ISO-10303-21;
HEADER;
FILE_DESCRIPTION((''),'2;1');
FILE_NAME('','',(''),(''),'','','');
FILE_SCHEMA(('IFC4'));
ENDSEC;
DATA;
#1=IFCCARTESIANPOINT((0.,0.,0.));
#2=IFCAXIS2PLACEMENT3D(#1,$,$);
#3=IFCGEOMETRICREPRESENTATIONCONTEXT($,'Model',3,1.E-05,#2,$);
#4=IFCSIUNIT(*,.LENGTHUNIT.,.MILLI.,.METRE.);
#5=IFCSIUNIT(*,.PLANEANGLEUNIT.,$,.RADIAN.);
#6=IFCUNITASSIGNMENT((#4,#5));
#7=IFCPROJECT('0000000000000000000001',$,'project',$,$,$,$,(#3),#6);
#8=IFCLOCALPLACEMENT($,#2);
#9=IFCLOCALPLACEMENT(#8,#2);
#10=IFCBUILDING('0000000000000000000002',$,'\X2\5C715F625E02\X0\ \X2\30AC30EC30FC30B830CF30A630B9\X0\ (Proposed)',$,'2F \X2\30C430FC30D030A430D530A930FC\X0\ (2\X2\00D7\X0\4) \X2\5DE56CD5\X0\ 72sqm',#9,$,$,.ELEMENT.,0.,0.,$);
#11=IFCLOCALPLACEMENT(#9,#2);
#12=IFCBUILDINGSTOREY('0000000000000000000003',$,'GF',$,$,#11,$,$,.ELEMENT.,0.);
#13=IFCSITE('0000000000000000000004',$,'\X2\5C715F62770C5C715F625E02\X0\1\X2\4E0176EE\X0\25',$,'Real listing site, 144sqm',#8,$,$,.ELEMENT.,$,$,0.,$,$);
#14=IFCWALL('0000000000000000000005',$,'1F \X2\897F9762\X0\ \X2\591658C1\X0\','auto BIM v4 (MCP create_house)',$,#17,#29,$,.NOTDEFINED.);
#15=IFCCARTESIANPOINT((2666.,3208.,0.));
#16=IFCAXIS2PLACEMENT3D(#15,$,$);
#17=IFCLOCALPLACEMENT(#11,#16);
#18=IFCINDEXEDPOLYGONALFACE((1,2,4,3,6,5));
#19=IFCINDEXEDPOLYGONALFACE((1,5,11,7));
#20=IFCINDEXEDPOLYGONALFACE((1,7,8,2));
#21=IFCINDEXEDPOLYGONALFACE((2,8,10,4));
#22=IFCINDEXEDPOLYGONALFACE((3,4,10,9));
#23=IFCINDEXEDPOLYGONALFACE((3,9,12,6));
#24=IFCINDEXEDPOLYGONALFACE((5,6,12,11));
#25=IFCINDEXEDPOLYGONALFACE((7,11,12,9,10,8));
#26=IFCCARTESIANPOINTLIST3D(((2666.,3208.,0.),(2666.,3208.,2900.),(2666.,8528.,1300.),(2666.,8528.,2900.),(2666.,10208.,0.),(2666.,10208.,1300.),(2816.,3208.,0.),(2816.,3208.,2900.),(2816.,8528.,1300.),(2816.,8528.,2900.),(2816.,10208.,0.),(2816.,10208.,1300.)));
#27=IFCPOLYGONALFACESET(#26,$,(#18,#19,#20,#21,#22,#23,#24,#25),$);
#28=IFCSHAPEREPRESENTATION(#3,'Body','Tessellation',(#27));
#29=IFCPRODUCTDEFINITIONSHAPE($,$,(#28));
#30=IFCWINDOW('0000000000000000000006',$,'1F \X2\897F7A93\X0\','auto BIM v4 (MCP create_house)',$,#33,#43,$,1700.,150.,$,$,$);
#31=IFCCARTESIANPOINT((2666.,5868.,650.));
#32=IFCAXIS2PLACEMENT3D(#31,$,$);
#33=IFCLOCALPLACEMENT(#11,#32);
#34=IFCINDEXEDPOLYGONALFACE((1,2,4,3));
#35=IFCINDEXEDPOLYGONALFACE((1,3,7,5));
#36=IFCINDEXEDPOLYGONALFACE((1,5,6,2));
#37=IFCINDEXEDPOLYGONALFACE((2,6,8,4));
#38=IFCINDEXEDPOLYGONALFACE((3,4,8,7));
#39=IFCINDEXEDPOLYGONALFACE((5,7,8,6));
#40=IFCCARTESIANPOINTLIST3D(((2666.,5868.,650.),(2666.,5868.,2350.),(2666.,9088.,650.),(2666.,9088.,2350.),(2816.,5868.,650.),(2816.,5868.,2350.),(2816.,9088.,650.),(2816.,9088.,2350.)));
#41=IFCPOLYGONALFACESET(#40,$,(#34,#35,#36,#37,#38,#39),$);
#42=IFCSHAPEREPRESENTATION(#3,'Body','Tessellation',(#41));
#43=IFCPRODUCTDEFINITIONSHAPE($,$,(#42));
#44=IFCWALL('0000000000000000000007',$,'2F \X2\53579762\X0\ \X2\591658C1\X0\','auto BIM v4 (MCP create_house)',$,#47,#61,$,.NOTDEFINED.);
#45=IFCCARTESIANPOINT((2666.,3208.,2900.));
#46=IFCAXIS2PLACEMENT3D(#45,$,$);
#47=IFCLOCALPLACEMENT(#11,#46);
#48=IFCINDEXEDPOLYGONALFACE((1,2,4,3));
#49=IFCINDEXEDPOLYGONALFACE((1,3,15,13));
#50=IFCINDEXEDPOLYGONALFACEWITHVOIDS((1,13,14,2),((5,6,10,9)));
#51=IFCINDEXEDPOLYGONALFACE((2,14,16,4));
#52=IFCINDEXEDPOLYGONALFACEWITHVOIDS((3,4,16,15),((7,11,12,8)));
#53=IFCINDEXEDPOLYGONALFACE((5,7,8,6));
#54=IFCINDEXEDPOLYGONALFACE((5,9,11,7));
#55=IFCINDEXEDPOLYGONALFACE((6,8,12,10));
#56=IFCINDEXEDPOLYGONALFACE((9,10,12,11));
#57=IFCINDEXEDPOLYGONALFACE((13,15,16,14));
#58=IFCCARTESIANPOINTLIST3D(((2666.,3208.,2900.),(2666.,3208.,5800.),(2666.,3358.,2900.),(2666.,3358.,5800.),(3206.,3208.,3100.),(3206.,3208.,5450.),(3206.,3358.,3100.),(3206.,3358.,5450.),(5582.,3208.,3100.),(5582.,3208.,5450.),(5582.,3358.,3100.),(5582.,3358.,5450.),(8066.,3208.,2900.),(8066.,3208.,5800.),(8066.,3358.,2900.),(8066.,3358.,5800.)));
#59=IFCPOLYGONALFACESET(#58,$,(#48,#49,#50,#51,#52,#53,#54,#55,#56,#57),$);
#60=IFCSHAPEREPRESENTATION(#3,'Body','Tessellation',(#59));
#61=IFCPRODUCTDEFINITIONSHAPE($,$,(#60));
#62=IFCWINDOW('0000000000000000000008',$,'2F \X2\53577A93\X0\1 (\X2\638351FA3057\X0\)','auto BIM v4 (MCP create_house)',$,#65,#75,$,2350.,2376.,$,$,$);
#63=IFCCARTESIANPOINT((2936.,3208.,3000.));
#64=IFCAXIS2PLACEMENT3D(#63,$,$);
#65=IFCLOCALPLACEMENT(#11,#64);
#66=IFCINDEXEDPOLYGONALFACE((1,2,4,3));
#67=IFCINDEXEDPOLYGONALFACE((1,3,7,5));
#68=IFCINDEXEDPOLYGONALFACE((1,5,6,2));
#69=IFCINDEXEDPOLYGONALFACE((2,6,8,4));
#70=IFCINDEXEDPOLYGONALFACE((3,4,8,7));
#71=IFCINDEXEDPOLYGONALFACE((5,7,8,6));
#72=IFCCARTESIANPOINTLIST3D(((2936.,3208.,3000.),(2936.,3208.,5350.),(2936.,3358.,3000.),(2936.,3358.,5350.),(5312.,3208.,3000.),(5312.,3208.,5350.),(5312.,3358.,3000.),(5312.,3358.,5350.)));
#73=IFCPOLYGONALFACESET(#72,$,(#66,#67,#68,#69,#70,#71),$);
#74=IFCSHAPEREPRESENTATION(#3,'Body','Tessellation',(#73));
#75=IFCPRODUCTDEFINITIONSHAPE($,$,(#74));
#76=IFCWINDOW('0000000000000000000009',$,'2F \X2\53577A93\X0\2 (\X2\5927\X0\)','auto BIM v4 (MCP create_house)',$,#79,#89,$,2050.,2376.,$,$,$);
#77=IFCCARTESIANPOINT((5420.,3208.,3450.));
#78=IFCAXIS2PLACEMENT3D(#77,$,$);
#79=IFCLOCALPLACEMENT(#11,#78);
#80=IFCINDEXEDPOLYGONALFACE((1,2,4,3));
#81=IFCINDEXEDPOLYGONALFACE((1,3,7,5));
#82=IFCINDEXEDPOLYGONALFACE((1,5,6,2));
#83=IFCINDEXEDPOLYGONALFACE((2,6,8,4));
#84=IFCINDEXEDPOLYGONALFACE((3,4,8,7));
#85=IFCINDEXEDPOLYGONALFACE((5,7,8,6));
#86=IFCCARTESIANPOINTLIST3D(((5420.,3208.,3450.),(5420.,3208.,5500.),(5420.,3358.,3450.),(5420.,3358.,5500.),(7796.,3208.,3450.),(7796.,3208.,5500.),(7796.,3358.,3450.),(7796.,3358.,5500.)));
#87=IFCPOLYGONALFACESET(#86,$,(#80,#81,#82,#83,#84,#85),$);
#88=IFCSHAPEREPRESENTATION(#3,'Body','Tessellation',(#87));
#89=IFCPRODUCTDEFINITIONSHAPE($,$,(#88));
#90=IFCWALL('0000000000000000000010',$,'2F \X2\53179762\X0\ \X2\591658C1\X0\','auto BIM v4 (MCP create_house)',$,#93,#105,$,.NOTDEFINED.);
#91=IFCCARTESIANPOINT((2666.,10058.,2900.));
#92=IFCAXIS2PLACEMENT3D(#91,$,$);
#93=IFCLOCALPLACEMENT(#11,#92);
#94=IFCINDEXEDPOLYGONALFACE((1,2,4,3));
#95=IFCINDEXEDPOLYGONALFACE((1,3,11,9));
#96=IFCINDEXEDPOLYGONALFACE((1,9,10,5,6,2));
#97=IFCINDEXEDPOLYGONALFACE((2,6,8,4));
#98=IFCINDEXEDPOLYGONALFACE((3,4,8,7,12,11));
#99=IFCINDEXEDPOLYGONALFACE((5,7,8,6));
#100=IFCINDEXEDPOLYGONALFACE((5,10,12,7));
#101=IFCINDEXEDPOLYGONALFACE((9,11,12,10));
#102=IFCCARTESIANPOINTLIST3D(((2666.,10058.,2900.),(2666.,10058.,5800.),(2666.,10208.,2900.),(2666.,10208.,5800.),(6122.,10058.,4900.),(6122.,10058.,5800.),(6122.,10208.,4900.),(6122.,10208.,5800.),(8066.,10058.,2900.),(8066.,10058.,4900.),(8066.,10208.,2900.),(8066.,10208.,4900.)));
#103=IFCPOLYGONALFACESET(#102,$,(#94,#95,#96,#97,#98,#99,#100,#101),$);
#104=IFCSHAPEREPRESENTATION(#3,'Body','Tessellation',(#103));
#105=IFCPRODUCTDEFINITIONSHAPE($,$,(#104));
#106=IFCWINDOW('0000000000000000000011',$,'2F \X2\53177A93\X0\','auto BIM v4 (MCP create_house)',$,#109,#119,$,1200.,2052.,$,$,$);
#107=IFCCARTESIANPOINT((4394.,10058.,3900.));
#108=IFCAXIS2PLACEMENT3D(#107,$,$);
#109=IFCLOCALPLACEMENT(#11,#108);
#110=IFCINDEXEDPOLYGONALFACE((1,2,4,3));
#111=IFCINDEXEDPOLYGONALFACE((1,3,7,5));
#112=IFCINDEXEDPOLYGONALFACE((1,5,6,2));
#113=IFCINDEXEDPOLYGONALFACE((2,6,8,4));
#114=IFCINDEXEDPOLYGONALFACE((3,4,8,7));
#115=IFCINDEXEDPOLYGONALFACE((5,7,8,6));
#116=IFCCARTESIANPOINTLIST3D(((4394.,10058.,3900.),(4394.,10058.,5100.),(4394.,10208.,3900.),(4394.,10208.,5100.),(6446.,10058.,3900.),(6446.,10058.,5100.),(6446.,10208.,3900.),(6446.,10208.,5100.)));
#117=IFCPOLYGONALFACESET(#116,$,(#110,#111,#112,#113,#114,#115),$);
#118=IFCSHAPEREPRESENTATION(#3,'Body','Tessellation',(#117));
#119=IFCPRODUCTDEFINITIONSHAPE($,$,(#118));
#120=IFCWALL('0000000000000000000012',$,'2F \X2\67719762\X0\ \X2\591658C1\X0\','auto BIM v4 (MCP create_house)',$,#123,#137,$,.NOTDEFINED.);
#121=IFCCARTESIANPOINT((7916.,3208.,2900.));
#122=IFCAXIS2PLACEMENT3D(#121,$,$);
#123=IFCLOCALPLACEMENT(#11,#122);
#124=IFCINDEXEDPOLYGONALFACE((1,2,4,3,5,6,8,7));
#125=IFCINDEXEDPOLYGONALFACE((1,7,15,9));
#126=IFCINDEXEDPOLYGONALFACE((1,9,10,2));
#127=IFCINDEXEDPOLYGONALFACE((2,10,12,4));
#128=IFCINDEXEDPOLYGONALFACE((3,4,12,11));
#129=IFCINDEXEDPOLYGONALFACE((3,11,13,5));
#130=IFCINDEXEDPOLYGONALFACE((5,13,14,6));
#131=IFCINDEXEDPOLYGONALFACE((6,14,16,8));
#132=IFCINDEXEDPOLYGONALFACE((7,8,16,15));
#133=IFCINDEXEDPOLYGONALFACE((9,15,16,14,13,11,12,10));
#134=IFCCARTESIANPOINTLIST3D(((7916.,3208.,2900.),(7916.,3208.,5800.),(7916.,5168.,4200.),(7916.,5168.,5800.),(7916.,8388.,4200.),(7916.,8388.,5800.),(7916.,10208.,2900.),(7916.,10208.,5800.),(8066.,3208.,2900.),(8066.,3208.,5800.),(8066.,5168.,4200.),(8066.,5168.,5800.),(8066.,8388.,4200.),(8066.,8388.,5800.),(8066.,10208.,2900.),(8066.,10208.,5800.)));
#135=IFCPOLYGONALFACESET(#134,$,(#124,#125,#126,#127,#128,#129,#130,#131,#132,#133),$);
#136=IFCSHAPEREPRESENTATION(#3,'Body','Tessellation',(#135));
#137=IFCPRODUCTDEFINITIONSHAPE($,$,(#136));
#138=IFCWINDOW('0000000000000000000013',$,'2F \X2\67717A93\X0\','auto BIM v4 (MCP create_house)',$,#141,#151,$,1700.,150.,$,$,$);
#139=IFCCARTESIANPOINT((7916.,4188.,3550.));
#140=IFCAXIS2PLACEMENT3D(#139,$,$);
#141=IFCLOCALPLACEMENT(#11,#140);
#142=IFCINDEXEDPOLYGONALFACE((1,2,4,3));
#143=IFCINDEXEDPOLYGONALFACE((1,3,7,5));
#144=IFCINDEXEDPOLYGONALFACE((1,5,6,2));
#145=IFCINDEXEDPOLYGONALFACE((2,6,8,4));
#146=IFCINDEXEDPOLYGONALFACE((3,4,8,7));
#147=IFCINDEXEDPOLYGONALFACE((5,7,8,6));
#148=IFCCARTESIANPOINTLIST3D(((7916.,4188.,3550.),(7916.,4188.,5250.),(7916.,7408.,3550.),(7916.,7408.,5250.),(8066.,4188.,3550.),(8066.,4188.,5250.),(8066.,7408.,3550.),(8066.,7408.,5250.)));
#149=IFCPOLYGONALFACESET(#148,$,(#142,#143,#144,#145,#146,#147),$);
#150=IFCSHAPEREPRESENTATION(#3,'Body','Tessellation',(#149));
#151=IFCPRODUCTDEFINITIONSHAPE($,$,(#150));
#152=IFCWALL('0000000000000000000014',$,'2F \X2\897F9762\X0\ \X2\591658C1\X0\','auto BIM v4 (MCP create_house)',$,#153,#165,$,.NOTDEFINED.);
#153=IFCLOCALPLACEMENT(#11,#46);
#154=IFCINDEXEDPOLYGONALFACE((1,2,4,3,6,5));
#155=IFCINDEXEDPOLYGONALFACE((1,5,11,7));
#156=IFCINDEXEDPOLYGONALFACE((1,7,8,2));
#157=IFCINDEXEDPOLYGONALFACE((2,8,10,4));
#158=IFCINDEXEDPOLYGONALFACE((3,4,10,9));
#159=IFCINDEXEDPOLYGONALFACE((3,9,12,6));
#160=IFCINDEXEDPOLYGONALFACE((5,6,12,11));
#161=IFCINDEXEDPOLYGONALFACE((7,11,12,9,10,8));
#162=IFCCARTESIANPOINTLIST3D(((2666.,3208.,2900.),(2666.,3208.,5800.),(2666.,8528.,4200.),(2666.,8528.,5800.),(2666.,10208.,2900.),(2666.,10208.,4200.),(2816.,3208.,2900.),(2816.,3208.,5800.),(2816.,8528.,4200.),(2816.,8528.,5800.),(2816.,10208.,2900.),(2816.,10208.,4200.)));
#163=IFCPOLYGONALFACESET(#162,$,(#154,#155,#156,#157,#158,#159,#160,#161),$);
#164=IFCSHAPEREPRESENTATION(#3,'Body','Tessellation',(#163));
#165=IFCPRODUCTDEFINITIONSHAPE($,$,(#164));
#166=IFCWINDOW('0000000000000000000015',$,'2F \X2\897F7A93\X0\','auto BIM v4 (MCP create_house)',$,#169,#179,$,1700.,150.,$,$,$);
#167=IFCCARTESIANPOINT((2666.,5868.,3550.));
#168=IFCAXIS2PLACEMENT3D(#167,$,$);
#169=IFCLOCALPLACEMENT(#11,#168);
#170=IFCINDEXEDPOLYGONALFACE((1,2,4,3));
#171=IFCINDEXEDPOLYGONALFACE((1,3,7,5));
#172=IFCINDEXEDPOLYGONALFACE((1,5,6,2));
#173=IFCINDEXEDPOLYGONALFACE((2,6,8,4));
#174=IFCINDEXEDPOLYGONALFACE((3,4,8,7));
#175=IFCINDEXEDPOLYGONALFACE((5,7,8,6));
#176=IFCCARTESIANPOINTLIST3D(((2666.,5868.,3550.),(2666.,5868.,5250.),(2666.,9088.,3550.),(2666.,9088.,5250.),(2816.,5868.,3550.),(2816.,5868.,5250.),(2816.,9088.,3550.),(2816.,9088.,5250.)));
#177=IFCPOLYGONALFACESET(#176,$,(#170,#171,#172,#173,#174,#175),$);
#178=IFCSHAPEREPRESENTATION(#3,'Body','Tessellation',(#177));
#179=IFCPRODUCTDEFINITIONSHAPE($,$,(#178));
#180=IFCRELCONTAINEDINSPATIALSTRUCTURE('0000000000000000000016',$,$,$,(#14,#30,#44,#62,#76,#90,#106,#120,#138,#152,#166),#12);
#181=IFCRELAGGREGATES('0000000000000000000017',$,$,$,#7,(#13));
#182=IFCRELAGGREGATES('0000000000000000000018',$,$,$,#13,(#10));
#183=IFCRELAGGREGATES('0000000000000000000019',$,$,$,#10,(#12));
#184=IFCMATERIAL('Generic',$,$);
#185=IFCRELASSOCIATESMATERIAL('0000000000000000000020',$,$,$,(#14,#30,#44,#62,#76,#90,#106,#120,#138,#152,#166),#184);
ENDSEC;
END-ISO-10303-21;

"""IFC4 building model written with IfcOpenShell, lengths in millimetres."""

from ifc_helpers import new_model, si_unit, frame, frame_2d, origin, place, context, project, spatial, rectangle, extrude, material, element, fill, save


model = new_model("IFC4")

# Units and contexts
model_context = context("Model", 3, precision=1e-05, world=origin())
ifc_project = project(units=[si_unit("LENGTHUNIT", "METRE", prefix="MILLI"), si_unit("PLANEANGLEUNIT", "RADIAN")], contexts=[model_context])

# Site, building, storey
site_placement = place(None, origin())
site = spatial("IfcSite", under=ifc_project, at=site_placement, Name="山形県山形市1丁目25", ObjectType="Real listing site, 144sqm", CompositionType="ELEMENT", RefElevation=0.0)
building_placement = place(site_placement, origin())
building = spatial("IfcBuilding", under=site, at=building_placement, Name="山形市 ガレージハウス (Proposed)", ObjectType="2F ツーバイフォー (2×4) 工法 72sqm", CompositionType="ELEMENT", ElevationOfRefHeight=0.0, ElevationOfTerrain=0.0)
storey_placement = place(building_placement, origin())
storey = spatial("IfcBuildingStorey", under=building, at=storey_placement, Name="GF", CompositionType="ELEMENT", Elevation=0.0)

# Shared definitions
ifc_material = material(Name="Generic")

# Wall, opening, window
wall_1_placement = place(storey_placement, frame((2666.0, 3208.0, 0.0)))
wall_1 = element("IfcWall", 1, at=wall_1_placement, inside=storey, material=ifc_material, Name="1F 西面 外壁", Description="auto BIM v4 (MCP create_house)", PredefinedType="NOTDEFINED", context=model_context, shape_type="SweptSolid", body=[
    extrude(rectangle(XDim=150.0, YDim=7000.0, at=frame_2d((75.0, 3500.0))), frame((2666.0, 3208.0, 0.0)), (0.0, 0.0, 1.0), 2900.0),
])
opening_1_placement = place(storey_placement, frame((2666.0, 5868.0, 650.0)))
opening_1 = element("IfcOpeningElement", 2, at=opening_1_placement, cuts=wall_1, PredefinedType="NOTDEFINED", context=model_context, shape_type="SweptSolid", body=[
    extrude(rectangle(XDim=150.0, YDim=3220.0, at=frame_2d((75.0, 1610.0))), frame((2666.0, 5868.0, 650.0)), (0.0, 0.0, 1.0), 1700.0),
])
window_1_placement = place(storey_placement, frame((2666.0, 5868.0, 650.0)))
window_1 = element("IfcWindow", 3, at=window_1_placement, inside=storey, material=ifc_material, Name="1F 西窓", Description="auto BIM v4 (MCP create_house)", OverallHeight=1700.0, OverallWidth=150.0, context=model_context, shape_type="SweptSolid", body=[
    extrude(rectangle(XDim=150.0, YDim=3220.0, at=frame_2d((75.0, 1610.0))), frame((2666.0, 5868.0, 650.0)), (0.0, 0.0, 1.0), 1700.0),
])
fill(opening_1, window_1)

# Wall, openings, windows
wall_2_placement = place(storey_placement, frame((2666.0, 3208.0, 2900.0)))
wall_2 = element("IfcWall", 4, at=wall_2_placement, inside=storey, material=ifc_material, Name="2F 南面 外壁", Description="auto BIM v4 (MCP create_house)", PredefinedType="NOTDEFINED", context=model_context, shape_type="SweptSolid", body=[
    extrude(rectangle(XDim=5400.0, YDim=150.0, at=frame_2d((2700.0, 75.0))), frame((2666.0, 3208.0, 2900.0)), (0.0, 0.0, 1.0), 2900.0),
])
opening_2_placement = place(storey_placement, frame((2936.0, 3208.0, 3000.0)))
opening_2 = element("IfcOpeningElement", 5, at=opening_2_placement, cuts=wall_2, PredefinedType="NOTDEFINED", context=model_context, shape_type="SweptSolid", body=[
    extrude(rectangle(XDim=2376.0, YDim=150.0, at=frame_2d((1188.0, 75.0))), frame((2936.0, 3208.0, 3000.0)), (0.0, 0.0, 1.0), 2350.0),
])
opening_3_placement = place(storey_placement, frame((5420.0, 3208.0, 3450.0)))
opening_3 = element("IfcOpeningElement", 6, at=opening_3_placement, cuts=wall_2, PredefinedType="NOTDEFINED", context=model_context, shape_type="SweptSolid", body=[
    extrude(rectangle(XDim=2376.0, YDim=150.0, at=frame_2d((1188.0, 75.0))), frame((5420.0, 3208.0, 3450.0)), (0.0, 0.0, 1.0), 2050.0),
])
window_2_placement = place(storey_placement, frame((2936.0, 3208.0, 3000.0)))
window_2 = element("IfcWindow", 7, at=window_2_placement, inside=storey, material=ifc_material, Name="2F 南窓1 (掃出し)", Description="auto BIM v4 (MCP create_house)", OverallHeight=2350.0, OverallWidth=2376.0, context=model_context, shape_type="SweptSolid", body=[
    extrude(rectangle(XDim=2376.0, YDim=150.0, at=frame_2d((1188.0, 75.0))), frame((2936.0, 3208.0, 3000.0)), (0.0, 0.0, 1.0), 2350.0),
])
fill(opening_2, window_2)
window_3_placement = place(storey_placement, frame((5420.0, 3208.0, 3450.0)))
window_3 = element("IfcWindow", 8, at=window_3_placement, inside=storey, material=ifc_material, Name="2F 南窓2 (大)", Description="auto BIM v4 (MCP create_house)", OverallHeight=2050.0, OverallWidth=2376.0, context=model_context, shape_type="SweptSolid", body=[
    extrude(rectangle(XDim=2376.0, YDim=150.0, at=frame_2d((1188.0, 75.0))), frame((5420.0, 3208.0, 3450.0)), (0.0, 0.0, 1.0), 2050.0),
])
fill(opening_3, window_3)

# Walls, openings, windows
wall_3_placement = place(storey_placement, frame((2666.0, 10058.0, 2900.0)))
wall_3 = element("IfcWall", 9, at=wall_3_placement, inside=storey, material=ifc_material, Name="2F 北面 外壁", Description="auto BIM v4 (MCP create_house)", PredefinedType="NOTDEFINED", context=model_context, shape_type="SweptSolid", body=[
    extrude(rectangle(XDim=5400.0, YDim=150.0, at=frame_2d((2700.0, 75.0))), frame((2666.0, 10058.0, 2900.0)), (0.0, 0.0, 1.0), 2900.0),
])
opening_4_placement = place(storey_placement, frame((4394.0, 10058.0, 3900.0)))
opening_4 = element("IfcOpeningElement", 10, at=opening_4_placement, cuts=wall_3, PredefinedType="NOTDEFINED", context=model_context, shape_type="SweptSolid", body=[
    extrude(rectangle(XDim=2052.0, YDim=150.0, at=frame_2d((1026.0, 75.0))), frame((4394.0, 10058.0, 3900.0)), (0.0, 0.0, 1.0), 1200.0),
])
window_4_placement = place(storey_placement, frame((4394.0, 10058.0, 3900.0)))
window_4 = element("IfcWindow", 11, at=window_4_placement, inside=storey, material=ifc_material, Name="2F 北窓", Description="auto BIM v4 (MCP create_house)", OverallHeight=1200.0, OverallWidth=2052.0, context=model_context, shape_type="SweptSolid", body=[
    extrude(rectangle(XDim=2052.0, YDim=150.0, at=frame_2d((1026.0, 75.0))), frame((4394.0, 10058.0, 3900.0)), (0.0, 0.0, 1.0), 1200.0),
])
fill(opening_4, window_4)
wall_4_placement = place(storey_placement, frame((7916.0, 3208.0, 2900.0)))
wall_4 = element("IfcWall", 12, at=wall_4_placement, inside=storey, material=ifc_material, Name="2F 東面 外壁", Description="auto BIM v4 (MCP create_house)", PredefinedType="NOTDEFINED", context=model_context, shape_type="SweptSolid", body=[
    extrude(rectangle(XDim=150.0, YDim=7000.0, at=frame_2d((75.0, 3500.0))), frame((7916.0, 3208.0, 2900.0)), (0.0, 0.0, 1.0), 2900.0),
])
opening_5_placement = place(storey_placement, frame((7916.0, 4188.0, 3550.0)))
opening_5 = element("IfcOpeningElement", 13, at=opening_5_placement, cuts=wall_4, PredefinedType="NOTDEFINED", context=model_context, shape_type="SweptSolid", body=[
    extrude(rectangle(XDim=150.0, YDim=3220.0, at=frame_2d((75.0, 1610.0))), frame((7916.0, 4188.0, 3550.0)), (0.0, 0.0, 1.0), 1700.0),
])
window_5_placement = place(storey_placement, frame((7916.0, 4188.0, 3550.0)))
window_5 = element("IfcWindow", 14, at=window_5_placement, inside=storey, material=ifc_material, Name="2F 東窓", Description="auto BIM v4 (MCP create_house)", OverallHeight=1700.0, OverallWidth=150.0, context=model_context, shape_type="SweptSolid", body=[
    extrude(rectangle(XDim=150.0, YDim=3220.0, at=frame_2d((75.0, 1610.0))), frame((7916.0, 4188.0, 3550.0)), (0.0, 0.0, 1.0), 1700.0),
])
fill(opening_5, window_5)
wall_5_placement = place(storey_placement, frame((2666.0, 3208.0, 2900.0)))
wall_5 = element("IfcWall", 15, at=wall_5_placement, inside=storey, material=ifc_material, Name="2F 西面 外壁", Description="auto BIM v4 (MCP create_house)", PredefinedType="NOTDEFINED", context=model_context, shape_type="SweptSolid", body=[
    extrude(rectangle(XDim=150.0, YDim=7000.0, at=frame_2d((75.0, 3500.0))), frame((2666.0, 3208.0, 2900.0)), (0.0, 0.0, 1.0), 2900.0),
])
opening_6_placement = place(storey_placement, frame((2666.0, 5868.0, 3550.0)))
opening_6 = element("IfcOpeningElement", 16, at=opening_6_placement, cuts=wall_5, PredefinedType="NOTDEFINED", context=model_context, shape_type="SweptSolid", body=[
    extrude(rectangle(XDim=150.0, YDim=3220.0, at=frame_2d((75.0, 1610.0))), frame((2666.0, 5868.0, 3550.0)), (0.0, 0.0, 1.0), 1700.0),
])
window_6_placement = place(storey_placement, frame((2666.0, 5868.0, 3550.0)))
window_6 = element("IfcWindow", 17, at=window_6_placement, inside=storey, material=ifc_material, Name="2F 西窓", Description="auto BIM v4 (MCP create_house)", OverallHeight=1700.0, OverallWidth=150.0, context=model_context, shape_type="SweptSolid", body=[
    extrude(rectangle(XDim=150.0, YDim=3220.0, at=frame_2d((75.0, 1610.0))), frame((2666.0, 5868.0, 3550.0)), (0.0, 0.0, 1.0), 1700.0),
])
fill(opening_6, window_6)

save(model, "model.ifc")
